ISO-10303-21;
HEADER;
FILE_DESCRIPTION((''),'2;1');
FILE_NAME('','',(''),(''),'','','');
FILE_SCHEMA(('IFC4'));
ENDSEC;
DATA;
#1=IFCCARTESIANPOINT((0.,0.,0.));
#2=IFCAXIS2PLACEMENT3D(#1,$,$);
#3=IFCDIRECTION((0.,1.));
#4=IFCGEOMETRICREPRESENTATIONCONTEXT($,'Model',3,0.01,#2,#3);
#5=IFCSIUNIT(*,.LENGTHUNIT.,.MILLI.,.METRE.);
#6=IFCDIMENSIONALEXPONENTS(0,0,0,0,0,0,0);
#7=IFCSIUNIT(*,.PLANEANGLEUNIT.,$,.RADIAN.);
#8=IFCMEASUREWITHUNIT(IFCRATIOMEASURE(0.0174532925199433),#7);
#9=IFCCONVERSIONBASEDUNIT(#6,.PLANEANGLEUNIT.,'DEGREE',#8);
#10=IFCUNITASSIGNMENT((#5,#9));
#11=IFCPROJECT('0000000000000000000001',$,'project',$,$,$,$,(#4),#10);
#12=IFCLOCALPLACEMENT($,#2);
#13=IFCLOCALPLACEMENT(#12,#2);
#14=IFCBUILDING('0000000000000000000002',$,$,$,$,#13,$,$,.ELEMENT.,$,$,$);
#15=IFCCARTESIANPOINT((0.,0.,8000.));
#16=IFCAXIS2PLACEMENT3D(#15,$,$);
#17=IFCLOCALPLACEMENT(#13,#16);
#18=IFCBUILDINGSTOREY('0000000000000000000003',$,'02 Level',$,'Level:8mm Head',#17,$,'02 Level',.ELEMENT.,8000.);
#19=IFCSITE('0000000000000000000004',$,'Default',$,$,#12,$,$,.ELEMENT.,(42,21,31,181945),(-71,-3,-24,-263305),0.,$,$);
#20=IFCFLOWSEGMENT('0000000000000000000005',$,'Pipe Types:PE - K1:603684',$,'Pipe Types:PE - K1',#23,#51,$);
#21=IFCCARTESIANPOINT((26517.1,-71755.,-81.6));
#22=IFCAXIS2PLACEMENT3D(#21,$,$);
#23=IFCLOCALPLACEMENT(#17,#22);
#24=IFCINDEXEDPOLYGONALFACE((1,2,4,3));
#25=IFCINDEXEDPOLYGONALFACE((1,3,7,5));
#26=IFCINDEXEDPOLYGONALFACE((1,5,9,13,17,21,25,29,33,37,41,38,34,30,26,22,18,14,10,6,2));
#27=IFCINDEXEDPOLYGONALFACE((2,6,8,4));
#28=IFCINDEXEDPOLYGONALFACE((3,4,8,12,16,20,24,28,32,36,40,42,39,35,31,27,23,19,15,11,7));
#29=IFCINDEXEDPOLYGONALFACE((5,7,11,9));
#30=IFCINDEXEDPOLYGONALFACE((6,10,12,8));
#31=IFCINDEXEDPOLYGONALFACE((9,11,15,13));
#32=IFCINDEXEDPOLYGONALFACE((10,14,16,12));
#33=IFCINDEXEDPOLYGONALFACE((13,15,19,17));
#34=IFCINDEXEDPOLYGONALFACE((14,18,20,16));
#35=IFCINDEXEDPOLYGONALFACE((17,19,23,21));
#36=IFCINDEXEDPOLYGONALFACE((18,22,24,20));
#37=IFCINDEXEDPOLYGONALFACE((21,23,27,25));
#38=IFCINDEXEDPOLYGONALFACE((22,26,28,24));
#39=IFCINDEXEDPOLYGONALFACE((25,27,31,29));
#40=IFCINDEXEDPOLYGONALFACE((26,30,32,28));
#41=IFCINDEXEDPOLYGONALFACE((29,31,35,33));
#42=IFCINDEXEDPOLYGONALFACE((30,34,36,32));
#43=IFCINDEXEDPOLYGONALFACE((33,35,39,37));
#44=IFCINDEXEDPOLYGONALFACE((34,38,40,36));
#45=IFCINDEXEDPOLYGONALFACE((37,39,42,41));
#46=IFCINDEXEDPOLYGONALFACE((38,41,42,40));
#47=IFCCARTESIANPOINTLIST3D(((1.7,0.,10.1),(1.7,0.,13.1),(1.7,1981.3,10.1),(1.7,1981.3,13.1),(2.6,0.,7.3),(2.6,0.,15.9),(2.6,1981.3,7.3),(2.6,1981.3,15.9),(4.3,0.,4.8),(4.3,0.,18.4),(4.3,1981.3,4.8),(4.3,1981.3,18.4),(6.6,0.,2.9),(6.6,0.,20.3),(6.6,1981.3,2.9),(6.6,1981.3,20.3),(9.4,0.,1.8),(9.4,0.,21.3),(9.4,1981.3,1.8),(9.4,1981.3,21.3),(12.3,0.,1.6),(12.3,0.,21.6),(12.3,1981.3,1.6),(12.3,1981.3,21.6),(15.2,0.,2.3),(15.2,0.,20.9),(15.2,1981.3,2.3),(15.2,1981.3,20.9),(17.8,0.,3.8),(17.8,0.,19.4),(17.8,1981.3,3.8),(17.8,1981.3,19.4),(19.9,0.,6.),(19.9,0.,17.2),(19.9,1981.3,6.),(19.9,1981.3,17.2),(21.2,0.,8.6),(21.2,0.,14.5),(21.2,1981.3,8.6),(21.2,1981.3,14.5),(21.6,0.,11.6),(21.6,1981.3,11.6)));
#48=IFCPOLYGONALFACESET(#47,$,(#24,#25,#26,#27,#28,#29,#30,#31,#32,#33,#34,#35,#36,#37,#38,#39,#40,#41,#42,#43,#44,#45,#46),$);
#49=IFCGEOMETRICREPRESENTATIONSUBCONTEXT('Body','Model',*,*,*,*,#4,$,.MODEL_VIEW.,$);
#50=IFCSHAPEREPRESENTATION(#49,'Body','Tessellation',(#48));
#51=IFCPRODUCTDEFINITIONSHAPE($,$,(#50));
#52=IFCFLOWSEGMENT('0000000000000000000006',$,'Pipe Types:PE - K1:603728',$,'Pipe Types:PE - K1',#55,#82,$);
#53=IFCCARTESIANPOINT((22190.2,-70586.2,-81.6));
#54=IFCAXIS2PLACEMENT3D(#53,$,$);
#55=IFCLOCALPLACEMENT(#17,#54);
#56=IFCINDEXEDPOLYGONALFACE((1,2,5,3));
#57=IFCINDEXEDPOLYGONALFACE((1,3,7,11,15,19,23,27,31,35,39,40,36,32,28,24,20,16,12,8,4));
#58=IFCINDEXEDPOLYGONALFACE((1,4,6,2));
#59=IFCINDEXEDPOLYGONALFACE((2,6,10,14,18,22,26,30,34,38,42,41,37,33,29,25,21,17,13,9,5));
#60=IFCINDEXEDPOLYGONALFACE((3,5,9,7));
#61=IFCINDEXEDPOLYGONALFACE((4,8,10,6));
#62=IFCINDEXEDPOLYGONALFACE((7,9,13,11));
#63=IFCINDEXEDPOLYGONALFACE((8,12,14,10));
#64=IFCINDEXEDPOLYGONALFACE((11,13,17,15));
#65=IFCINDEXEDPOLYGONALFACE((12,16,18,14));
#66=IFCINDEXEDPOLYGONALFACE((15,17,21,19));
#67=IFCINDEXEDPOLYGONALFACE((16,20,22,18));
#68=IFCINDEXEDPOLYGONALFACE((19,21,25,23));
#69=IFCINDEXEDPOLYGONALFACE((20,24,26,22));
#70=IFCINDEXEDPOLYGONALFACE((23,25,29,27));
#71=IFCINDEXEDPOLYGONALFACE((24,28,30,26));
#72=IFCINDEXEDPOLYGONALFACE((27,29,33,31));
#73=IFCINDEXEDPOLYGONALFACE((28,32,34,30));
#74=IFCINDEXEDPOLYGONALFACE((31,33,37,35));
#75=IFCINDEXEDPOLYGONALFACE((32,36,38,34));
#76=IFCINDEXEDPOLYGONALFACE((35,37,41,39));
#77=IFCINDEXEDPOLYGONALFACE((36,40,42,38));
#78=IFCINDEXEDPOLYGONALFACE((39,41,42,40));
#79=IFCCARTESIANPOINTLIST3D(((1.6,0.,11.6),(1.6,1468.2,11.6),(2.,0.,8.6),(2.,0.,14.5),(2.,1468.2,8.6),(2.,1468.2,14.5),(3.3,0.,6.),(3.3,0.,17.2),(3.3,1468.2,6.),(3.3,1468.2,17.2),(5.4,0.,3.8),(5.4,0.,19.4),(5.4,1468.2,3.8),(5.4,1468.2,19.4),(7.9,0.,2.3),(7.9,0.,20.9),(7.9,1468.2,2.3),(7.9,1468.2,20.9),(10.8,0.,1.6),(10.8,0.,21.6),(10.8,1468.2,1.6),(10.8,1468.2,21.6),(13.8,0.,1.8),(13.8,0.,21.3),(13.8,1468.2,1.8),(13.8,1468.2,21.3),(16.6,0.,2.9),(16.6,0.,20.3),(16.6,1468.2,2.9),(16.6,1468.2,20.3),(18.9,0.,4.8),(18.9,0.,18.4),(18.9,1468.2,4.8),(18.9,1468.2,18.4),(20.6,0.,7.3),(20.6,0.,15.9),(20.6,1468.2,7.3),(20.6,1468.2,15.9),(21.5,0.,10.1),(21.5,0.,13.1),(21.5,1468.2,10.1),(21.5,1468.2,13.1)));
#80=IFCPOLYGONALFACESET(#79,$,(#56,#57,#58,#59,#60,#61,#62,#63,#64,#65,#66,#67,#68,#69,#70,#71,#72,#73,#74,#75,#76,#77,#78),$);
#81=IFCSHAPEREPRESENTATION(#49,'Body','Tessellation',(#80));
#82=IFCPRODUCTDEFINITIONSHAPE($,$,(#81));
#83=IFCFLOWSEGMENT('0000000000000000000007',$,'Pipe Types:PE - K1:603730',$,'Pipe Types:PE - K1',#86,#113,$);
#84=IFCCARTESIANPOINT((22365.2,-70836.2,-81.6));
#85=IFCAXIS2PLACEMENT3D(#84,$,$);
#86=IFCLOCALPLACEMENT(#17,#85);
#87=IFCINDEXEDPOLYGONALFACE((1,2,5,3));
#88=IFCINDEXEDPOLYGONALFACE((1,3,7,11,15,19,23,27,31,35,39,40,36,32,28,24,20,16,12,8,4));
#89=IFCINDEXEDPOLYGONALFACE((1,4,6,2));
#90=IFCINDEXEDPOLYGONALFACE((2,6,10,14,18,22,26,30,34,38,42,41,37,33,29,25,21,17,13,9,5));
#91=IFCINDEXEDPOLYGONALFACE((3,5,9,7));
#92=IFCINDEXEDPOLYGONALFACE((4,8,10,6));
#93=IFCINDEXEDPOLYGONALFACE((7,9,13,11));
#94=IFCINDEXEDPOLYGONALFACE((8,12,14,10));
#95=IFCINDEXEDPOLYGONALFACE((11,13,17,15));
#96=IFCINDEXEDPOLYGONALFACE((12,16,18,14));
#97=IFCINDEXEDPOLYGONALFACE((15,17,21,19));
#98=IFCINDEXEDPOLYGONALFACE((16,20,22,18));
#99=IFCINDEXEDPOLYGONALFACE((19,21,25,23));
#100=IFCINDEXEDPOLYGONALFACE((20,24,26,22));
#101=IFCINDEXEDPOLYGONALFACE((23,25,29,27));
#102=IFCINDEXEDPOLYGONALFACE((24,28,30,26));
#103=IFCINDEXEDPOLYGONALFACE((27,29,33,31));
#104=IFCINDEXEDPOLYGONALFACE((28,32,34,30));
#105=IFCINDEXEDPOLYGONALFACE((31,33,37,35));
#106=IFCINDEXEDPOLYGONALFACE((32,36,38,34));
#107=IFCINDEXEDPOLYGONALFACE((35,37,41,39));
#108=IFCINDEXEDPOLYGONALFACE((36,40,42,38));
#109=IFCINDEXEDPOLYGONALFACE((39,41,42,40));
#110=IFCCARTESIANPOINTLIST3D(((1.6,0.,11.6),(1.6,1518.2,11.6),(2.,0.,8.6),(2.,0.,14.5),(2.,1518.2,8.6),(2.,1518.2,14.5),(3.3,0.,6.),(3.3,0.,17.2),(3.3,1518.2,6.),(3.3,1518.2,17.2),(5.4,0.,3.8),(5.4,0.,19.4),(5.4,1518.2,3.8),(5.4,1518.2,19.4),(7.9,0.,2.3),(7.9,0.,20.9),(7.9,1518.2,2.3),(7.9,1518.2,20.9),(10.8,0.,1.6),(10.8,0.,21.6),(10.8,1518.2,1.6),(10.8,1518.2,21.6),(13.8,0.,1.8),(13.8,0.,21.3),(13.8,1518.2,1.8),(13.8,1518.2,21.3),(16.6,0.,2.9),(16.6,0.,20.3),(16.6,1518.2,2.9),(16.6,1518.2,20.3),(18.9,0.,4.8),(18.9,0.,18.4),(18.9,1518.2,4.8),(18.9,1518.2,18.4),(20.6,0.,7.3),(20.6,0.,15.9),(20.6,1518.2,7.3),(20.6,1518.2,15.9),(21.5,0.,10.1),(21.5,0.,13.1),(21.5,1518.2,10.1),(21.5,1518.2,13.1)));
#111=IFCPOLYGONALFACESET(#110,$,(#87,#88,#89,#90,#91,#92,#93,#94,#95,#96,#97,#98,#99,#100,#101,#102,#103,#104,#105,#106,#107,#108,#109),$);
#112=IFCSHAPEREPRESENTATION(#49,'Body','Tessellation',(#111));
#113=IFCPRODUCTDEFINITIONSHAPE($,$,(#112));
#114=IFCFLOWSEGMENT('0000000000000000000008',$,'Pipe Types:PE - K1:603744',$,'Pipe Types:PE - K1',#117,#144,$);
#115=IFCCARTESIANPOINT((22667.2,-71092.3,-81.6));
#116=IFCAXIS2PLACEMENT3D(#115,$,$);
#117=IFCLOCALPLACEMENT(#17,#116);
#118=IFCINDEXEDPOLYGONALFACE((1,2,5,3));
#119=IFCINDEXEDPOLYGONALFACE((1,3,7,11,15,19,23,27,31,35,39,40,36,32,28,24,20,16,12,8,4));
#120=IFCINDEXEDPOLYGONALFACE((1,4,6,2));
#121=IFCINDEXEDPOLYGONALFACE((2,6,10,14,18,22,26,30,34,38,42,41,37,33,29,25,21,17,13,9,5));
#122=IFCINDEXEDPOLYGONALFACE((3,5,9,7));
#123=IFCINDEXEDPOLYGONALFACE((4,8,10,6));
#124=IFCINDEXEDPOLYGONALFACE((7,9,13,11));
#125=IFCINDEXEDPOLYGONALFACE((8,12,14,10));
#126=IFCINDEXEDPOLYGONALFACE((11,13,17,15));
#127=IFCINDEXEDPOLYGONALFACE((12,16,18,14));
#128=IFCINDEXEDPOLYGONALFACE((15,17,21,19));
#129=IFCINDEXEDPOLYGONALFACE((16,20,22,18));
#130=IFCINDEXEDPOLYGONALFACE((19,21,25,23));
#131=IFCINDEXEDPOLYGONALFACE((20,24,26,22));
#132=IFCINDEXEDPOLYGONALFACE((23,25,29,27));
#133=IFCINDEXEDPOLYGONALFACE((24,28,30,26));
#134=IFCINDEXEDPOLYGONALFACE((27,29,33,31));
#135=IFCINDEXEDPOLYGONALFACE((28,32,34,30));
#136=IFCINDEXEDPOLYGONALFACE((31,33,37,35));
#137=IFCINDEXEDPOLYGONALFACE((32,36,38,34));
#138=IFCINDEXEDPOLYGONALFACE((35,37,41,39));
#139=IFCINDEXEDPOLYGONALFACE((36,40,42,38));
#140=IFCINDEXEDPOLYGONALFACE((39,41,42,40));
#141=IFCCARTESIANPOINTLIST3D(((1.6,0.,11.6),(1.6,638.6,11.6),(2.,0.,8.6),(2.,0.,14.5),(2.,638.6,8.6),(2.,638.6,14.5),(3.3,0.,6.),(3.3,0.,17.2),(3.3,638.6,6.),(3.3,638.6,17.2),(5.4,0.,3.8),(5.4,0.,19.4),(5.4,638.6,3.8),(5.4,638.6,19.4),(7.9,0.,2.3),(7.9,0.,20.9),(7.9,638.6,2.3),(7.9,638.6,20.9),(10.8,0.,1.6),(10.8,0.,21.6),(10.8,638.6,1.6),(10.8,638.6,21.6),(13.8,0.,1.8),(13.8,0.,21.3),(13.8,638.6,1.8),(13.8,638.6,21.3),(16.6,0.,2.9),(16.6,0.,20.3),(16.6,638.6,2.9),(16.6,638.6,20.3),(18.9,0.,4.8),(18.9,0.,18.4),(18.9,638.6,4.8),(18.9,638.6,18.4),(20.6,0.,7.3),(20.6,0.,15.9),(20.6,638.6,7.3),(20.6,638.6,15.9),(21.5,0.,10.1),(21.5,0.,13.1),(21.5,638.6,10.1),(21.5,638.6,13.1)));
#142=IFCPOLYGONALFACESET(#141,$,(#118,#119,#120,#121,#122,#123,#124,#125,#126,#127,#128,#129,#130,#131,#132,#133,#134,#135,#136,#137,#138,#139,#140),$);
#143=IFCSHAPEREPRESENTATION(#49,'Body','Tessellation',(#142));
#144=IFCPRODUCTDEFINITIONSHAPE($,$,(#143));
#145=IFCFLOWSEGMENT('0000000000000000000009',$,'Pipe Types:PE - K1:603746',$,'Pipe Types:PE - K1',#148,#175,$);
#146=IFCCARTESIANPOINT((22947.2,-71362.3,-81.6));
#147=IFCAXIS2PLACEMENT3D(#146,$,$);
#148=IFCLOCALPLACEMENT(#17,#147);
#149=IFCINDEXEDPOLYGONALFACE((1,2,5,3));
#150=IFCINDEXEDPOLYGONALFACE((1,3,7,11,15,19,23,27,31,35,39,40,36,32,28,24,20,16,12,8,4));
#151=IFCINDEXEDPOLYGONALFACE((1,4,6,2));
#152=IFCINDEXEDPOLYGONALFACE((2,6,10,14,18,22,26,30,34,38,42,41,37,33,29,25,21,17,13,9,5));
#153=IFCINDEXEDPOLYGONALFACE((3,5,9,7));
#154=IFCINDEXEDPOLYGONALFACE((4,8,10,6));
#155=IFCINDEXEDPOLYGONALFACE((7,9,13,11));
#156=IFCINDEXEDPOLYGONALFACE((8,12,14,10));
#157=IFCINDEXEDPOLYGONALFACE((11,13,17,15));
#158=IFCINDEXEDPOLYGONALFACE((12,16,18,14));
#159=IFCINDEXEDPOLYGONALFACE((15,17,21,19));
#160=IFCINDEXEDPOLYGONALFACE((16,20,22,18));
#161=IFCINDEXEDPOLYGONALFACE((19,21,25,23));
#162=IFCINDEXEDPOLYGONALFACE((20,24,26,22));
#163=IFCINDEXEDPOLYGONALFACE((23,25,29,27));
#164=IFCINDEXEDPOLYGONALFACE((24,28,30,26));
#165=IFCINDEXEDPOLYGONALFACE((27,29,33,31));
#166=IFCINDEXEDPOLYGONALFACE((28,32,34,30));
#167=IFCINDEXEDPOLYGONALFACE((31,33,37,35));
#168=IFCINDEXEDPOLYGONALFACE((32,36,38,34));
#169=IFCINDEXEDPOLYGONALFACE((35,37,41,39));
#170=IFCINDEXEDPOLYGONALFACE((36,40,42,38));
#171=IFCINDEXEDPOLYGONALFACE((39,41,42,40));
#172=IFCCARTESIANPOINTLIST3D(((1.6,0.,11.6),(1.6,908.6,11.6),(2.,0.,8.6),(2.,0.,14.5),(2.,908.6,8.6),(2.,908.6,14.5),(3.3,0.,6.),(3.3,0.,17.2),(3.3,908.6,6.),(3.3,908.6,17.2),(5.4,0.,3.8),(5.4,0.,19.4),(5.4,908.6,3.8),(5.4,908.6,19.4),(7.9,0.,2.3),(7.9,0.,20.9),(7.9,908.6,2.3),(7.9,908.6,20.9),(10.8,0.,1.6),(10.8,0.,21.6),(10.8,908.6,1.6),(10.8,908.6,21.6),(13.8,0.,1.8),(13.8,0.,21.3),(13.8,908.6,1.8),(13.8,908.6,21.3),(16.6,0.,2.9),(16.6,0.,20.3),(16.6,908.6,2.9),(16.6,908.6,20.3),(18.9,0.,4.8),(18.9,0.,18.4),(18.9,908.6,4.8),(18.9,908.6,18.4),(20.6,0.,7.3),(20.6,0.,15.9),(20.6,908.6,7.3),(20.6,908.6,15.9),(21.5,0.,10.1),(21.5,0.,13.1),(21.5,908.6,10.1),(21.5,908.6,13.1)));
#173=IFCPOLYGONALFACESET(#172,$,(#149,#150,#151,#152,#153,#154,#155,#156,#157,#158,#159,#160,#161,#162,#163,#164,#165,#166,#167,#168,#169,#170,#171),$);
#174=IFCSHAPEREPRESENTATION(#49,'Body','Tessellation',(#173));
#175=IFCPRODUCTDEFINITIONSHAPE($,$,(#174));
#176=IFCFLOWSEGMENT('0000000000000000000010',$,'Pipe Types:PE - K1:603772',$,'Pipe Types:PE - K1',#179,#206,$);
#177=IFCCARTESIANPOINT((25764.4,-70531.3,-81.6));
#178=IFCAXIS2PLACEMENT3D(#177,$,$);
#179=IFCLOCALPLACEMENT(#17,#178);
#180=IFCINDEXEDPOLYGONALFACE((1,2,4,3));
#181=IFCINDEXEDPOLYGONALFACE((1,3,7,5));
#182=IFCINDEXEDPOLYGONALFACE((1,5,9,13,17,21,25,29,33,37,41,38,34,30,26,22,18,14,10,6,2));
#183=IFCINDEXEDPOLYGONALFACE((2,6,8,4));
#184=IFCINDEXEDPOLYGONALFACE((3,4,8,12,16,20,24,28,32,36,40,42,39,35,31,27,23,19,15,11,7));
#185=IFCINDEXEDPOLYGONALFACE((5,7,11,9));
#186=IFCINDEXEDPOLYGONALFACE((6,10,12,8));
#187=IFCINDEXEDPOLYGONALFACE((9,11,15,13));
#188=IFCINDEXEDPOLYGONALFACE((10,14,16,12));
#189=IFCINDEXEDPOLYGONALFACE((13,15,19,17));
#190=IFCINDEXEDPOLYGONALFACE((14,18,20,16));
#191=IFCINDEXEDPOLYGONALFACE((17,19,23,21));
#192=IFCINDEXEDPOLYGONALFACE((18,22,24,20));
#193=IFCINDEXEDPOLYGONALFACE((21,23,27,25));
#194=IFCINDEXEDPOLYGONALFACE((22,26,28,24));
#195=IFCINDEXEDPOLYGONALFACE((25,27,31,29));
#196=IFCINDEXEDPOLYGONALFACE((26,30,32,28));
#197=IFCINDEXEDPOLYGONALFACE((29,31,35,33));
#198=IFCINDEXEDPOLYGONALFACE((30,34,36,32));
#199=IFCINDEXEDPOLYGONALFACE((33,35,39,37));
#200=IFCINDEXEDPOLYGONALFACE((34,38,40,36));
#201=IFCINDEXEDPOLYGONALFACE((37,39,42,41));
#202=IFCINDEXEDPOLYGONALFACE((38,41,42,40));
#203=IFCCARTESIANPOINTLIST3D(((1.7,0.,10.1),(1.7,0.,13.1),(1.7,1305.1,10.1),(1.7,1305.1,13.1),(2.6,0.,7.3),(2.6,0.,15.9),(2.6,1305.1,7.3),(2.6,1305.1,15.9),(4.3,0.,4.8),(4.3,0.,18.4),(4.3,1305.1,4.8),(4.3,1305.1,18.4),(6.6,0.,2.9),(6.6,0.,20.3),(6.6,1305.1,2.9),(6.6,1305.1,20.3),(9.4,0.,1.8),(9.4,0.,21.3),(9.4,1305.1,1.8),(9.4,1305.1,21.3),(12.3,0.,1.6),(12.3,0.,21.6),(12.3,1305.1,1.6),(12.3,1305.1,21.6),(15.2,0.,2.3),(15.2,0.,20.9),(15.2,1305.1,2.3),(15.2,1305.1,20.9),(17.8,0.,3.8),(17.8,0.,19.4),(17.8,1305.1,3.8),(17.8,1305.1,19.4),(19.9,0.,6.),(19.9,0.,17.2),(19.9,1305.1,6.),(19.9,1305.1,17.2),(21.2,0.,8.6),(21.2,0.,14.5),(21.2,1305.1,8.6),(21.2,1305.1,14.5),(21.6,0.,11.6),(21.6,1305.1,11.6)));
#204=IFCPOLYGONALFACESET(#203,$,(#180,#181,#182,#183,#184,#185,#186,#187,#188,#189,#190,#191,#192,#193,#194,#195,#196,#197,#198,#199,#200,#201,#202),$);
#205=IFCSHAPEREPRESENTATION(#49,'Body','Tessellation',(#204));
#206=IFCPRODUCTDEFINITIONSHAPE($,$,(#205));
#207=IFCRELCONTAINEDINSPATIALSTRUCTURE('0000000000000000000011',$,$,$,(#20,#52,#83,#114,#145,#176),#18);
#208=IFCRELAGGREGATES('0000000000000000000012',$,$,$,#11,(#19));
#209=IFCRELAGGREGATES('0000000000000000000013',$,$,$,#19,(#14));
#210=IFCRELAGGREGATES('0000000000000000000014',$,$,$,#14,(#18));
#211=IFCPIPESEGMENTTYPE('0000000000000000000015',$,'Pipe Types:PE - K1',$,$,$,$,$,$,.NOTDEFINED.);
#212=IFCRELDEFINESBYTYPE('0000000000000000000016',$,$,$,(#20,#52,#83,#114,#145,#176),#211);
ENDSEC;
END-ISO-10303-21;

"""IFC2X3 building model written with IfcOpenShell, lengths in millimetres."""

from ifc_helpers import new_model, entity, si_unit, converted_unit, direction, frame, frame_2d, origin, origin_2d_with_axis, place, context, subcontext, project, spatial, circle, extrude, type_object, element, save


model = new_model("IFC2X3")

# Units and contexts
model_context = context("Model", 3, precision=0.01, world=origin(), true_north=direction((0.0, 1.0)))
body_context = subcontext(model_context, "Body", "Model", "MODEL_VIEW")
ifc_project = project(units=[si_unit("LENGTHUNIT", "METRE", prefix="MILLI"), converted_unit("PLANEANGLEUNIT", "DEGREE", entity("IfcRatioMeasure", 0.0174532925199433), si_unit("PLANEANGLEUNIT", "RADIAN"), dimensions=[0, 0, 0, 0, 0, 0, 0])], contexts=[model_context])

# Site, building, storey
site_placement = place(None, origin())
site = spatial("IfcSite", under=ifc_project, at=site_placement, Name="Default", CompositionType="ELEMENT", RefLatitude=(42, 21, 31, 181945), RefLongitude=(-71, -3, -24, -263305), RefElevation=0.0)
building_placement = place(site_placement, origin())
building = spatial("IfcBuilding", under=site, at=building_placement, CompositionType="ELEMENT")
storey_placement = place(building_placement, frame((0.0, 0.0, 8000.0)))
storey = spatial("IfcBuildingStorey", under=building, at=storey_placement, Name="02 Level", ObjectType="Level:8mm Head", LongName="02 Level", CompositionType="ELEMENT", Elevation=8000.0)

# Flow segments
pipe_segment_type = type_object("IfcPipeSegmentType", Name="Pipe Types:PE - K1", PredefinedType="NOTDEFINED")
flow_segment_1_placement = place(storey_placement, frame((26517.1, -71755.0, -81.6)))
element("IfcFlowSegment", 1, at=flow_segment_1_placement, inside=storey, type_object=pipe_segment_type, Name="Pipe Types:PE - K1:603684", ObjectType="Pipe Types:PE - K1", context=body_context, shape_type="SweptSolid", body=[
    extrude(circle(Radius=10.0, at=origin_2d_with_axis()), frame((11.6, 0.0, 11.6), z_axis=(0.0, 1.0, 0.0), x_axis=(1.0, 0.0, 0.0)), (0.0, 0.0, 1.0), 1981.3),
])
flow_segment_2_placement = place(storey_placement, frame((22190.2, -70586.2, -81.6)))
element("IfcFlowSegment", 2, at=flow_segment_2_placement, inside=storey, type_object=pipe_segment_type, Name="Pipe Types:PE - K1:603728", ObjectType="Pipe Types:PE - K1", context=body_context, shape_type="SweptSolid", body=[
    extrude(circle(Radius=10.0, at=frame_2d((0.0, 0.0), x_axis=(1.0, 0.0))), frame((11.6, 0.0, 11.6), z_axis=(0.0, 1.0, 0.0), x_axis=(-1.0, 0.0, 0.0)), (0.0, 0.0, 1.0), 1468.2),
])
flow_segment_3_placement = place(storey_placement, frame((22365.2, -70836.2, -81.6)))
element("IfcFlowSegment", 3, at=flow_segment_3_placement, inside=storey, type_object=pipe_segment_type, Name="Pipe Types:PE - K1:603730", ObjectType="Pipe Types:PE - K1", context=body_context, shape_type="SweptSolid", body=[
    extrude(circle(Radius=10.0, at=frame_2d((0.0, 0.0), x_axis=(1.0, 0.0))), frame((11.6, 0.0, 11.6), z_axis=(0.0, 1.0, 0.0), x_axis=(-1.0, 0.0, 0.0)), (0.0, 0.0, 1.0), 1518.2),
])
flow_segment_4_placement = place(storey_placement, frame((22667.2, -71092.3, -81.6)))
element("IfcFlowSegment", 4, at=flow_segment_4_placement, inside=storey, type_object=pipe_segment_type, Name="Pipe Types:PE - K1:603744", ObjectType="Pipe Types:PE - K1", context=body_context, shape_type="SweptSolid", body=[
    extrude(circle(Radius=10.0, at=frame_2d((0.0, 0.0), x_axis=(1.0, 0.0))), frame((11.6, 0.0, 11.6), z_axis=(0.0, 1.0, 0.0), x_axis=(-1.0, 0.0, 0.0)), (0.0, 0.0, 1.0), 638.6),
])
flow_segment_5_placement = place(storey_placement, frame((22947.2, -71362.3, -81.6)))
element("IfcFlowSegment", 5, at=flow_segment_5_placement, inside=storey, type_object=pipe_segment_type, Name="Pipe Types:PE - K1:603746", ObjectType="Pipe Types:PE - K1", context=body_context, shape_type="SweptSolid", body=[
    extrude(circle(Radius=10.0, at=frame_2d((0.0, 0.0), x_axis=(1.0, 0.0))), frame((11.6, 0.0, 11.6), z_axis=(0.0, 1.0, 0.0), x_axis=(-1.0, 0.0, 0.0)), (0.0, 0.0, 1.0), 908.6),
])
flow_segment_6_placement = place(storey_placement, frame((25764.4, -70531.3, -81.6)))
element("IfcFlowSegment", 6, at=flow_segment_6_placement, inside=storey, type_object=pipe_segment_type, Name="Pipe Types:PE - K1:603772", ObjectType="Pipe Types:PE - K1", context=body_context, shape_type="SweptSolid", body=[
    extrude(circle(Radius=10.0, at=origin_2d_with_axis()), frame((11.6, 0.0, 11.6), z_axis=(0.0, 1.0, 0.0), x_axis=(1.0, 0.0, 0.0)), (0.0, 0.0, 1.0), 1305.1),
])

save(model, "model.ifc")
